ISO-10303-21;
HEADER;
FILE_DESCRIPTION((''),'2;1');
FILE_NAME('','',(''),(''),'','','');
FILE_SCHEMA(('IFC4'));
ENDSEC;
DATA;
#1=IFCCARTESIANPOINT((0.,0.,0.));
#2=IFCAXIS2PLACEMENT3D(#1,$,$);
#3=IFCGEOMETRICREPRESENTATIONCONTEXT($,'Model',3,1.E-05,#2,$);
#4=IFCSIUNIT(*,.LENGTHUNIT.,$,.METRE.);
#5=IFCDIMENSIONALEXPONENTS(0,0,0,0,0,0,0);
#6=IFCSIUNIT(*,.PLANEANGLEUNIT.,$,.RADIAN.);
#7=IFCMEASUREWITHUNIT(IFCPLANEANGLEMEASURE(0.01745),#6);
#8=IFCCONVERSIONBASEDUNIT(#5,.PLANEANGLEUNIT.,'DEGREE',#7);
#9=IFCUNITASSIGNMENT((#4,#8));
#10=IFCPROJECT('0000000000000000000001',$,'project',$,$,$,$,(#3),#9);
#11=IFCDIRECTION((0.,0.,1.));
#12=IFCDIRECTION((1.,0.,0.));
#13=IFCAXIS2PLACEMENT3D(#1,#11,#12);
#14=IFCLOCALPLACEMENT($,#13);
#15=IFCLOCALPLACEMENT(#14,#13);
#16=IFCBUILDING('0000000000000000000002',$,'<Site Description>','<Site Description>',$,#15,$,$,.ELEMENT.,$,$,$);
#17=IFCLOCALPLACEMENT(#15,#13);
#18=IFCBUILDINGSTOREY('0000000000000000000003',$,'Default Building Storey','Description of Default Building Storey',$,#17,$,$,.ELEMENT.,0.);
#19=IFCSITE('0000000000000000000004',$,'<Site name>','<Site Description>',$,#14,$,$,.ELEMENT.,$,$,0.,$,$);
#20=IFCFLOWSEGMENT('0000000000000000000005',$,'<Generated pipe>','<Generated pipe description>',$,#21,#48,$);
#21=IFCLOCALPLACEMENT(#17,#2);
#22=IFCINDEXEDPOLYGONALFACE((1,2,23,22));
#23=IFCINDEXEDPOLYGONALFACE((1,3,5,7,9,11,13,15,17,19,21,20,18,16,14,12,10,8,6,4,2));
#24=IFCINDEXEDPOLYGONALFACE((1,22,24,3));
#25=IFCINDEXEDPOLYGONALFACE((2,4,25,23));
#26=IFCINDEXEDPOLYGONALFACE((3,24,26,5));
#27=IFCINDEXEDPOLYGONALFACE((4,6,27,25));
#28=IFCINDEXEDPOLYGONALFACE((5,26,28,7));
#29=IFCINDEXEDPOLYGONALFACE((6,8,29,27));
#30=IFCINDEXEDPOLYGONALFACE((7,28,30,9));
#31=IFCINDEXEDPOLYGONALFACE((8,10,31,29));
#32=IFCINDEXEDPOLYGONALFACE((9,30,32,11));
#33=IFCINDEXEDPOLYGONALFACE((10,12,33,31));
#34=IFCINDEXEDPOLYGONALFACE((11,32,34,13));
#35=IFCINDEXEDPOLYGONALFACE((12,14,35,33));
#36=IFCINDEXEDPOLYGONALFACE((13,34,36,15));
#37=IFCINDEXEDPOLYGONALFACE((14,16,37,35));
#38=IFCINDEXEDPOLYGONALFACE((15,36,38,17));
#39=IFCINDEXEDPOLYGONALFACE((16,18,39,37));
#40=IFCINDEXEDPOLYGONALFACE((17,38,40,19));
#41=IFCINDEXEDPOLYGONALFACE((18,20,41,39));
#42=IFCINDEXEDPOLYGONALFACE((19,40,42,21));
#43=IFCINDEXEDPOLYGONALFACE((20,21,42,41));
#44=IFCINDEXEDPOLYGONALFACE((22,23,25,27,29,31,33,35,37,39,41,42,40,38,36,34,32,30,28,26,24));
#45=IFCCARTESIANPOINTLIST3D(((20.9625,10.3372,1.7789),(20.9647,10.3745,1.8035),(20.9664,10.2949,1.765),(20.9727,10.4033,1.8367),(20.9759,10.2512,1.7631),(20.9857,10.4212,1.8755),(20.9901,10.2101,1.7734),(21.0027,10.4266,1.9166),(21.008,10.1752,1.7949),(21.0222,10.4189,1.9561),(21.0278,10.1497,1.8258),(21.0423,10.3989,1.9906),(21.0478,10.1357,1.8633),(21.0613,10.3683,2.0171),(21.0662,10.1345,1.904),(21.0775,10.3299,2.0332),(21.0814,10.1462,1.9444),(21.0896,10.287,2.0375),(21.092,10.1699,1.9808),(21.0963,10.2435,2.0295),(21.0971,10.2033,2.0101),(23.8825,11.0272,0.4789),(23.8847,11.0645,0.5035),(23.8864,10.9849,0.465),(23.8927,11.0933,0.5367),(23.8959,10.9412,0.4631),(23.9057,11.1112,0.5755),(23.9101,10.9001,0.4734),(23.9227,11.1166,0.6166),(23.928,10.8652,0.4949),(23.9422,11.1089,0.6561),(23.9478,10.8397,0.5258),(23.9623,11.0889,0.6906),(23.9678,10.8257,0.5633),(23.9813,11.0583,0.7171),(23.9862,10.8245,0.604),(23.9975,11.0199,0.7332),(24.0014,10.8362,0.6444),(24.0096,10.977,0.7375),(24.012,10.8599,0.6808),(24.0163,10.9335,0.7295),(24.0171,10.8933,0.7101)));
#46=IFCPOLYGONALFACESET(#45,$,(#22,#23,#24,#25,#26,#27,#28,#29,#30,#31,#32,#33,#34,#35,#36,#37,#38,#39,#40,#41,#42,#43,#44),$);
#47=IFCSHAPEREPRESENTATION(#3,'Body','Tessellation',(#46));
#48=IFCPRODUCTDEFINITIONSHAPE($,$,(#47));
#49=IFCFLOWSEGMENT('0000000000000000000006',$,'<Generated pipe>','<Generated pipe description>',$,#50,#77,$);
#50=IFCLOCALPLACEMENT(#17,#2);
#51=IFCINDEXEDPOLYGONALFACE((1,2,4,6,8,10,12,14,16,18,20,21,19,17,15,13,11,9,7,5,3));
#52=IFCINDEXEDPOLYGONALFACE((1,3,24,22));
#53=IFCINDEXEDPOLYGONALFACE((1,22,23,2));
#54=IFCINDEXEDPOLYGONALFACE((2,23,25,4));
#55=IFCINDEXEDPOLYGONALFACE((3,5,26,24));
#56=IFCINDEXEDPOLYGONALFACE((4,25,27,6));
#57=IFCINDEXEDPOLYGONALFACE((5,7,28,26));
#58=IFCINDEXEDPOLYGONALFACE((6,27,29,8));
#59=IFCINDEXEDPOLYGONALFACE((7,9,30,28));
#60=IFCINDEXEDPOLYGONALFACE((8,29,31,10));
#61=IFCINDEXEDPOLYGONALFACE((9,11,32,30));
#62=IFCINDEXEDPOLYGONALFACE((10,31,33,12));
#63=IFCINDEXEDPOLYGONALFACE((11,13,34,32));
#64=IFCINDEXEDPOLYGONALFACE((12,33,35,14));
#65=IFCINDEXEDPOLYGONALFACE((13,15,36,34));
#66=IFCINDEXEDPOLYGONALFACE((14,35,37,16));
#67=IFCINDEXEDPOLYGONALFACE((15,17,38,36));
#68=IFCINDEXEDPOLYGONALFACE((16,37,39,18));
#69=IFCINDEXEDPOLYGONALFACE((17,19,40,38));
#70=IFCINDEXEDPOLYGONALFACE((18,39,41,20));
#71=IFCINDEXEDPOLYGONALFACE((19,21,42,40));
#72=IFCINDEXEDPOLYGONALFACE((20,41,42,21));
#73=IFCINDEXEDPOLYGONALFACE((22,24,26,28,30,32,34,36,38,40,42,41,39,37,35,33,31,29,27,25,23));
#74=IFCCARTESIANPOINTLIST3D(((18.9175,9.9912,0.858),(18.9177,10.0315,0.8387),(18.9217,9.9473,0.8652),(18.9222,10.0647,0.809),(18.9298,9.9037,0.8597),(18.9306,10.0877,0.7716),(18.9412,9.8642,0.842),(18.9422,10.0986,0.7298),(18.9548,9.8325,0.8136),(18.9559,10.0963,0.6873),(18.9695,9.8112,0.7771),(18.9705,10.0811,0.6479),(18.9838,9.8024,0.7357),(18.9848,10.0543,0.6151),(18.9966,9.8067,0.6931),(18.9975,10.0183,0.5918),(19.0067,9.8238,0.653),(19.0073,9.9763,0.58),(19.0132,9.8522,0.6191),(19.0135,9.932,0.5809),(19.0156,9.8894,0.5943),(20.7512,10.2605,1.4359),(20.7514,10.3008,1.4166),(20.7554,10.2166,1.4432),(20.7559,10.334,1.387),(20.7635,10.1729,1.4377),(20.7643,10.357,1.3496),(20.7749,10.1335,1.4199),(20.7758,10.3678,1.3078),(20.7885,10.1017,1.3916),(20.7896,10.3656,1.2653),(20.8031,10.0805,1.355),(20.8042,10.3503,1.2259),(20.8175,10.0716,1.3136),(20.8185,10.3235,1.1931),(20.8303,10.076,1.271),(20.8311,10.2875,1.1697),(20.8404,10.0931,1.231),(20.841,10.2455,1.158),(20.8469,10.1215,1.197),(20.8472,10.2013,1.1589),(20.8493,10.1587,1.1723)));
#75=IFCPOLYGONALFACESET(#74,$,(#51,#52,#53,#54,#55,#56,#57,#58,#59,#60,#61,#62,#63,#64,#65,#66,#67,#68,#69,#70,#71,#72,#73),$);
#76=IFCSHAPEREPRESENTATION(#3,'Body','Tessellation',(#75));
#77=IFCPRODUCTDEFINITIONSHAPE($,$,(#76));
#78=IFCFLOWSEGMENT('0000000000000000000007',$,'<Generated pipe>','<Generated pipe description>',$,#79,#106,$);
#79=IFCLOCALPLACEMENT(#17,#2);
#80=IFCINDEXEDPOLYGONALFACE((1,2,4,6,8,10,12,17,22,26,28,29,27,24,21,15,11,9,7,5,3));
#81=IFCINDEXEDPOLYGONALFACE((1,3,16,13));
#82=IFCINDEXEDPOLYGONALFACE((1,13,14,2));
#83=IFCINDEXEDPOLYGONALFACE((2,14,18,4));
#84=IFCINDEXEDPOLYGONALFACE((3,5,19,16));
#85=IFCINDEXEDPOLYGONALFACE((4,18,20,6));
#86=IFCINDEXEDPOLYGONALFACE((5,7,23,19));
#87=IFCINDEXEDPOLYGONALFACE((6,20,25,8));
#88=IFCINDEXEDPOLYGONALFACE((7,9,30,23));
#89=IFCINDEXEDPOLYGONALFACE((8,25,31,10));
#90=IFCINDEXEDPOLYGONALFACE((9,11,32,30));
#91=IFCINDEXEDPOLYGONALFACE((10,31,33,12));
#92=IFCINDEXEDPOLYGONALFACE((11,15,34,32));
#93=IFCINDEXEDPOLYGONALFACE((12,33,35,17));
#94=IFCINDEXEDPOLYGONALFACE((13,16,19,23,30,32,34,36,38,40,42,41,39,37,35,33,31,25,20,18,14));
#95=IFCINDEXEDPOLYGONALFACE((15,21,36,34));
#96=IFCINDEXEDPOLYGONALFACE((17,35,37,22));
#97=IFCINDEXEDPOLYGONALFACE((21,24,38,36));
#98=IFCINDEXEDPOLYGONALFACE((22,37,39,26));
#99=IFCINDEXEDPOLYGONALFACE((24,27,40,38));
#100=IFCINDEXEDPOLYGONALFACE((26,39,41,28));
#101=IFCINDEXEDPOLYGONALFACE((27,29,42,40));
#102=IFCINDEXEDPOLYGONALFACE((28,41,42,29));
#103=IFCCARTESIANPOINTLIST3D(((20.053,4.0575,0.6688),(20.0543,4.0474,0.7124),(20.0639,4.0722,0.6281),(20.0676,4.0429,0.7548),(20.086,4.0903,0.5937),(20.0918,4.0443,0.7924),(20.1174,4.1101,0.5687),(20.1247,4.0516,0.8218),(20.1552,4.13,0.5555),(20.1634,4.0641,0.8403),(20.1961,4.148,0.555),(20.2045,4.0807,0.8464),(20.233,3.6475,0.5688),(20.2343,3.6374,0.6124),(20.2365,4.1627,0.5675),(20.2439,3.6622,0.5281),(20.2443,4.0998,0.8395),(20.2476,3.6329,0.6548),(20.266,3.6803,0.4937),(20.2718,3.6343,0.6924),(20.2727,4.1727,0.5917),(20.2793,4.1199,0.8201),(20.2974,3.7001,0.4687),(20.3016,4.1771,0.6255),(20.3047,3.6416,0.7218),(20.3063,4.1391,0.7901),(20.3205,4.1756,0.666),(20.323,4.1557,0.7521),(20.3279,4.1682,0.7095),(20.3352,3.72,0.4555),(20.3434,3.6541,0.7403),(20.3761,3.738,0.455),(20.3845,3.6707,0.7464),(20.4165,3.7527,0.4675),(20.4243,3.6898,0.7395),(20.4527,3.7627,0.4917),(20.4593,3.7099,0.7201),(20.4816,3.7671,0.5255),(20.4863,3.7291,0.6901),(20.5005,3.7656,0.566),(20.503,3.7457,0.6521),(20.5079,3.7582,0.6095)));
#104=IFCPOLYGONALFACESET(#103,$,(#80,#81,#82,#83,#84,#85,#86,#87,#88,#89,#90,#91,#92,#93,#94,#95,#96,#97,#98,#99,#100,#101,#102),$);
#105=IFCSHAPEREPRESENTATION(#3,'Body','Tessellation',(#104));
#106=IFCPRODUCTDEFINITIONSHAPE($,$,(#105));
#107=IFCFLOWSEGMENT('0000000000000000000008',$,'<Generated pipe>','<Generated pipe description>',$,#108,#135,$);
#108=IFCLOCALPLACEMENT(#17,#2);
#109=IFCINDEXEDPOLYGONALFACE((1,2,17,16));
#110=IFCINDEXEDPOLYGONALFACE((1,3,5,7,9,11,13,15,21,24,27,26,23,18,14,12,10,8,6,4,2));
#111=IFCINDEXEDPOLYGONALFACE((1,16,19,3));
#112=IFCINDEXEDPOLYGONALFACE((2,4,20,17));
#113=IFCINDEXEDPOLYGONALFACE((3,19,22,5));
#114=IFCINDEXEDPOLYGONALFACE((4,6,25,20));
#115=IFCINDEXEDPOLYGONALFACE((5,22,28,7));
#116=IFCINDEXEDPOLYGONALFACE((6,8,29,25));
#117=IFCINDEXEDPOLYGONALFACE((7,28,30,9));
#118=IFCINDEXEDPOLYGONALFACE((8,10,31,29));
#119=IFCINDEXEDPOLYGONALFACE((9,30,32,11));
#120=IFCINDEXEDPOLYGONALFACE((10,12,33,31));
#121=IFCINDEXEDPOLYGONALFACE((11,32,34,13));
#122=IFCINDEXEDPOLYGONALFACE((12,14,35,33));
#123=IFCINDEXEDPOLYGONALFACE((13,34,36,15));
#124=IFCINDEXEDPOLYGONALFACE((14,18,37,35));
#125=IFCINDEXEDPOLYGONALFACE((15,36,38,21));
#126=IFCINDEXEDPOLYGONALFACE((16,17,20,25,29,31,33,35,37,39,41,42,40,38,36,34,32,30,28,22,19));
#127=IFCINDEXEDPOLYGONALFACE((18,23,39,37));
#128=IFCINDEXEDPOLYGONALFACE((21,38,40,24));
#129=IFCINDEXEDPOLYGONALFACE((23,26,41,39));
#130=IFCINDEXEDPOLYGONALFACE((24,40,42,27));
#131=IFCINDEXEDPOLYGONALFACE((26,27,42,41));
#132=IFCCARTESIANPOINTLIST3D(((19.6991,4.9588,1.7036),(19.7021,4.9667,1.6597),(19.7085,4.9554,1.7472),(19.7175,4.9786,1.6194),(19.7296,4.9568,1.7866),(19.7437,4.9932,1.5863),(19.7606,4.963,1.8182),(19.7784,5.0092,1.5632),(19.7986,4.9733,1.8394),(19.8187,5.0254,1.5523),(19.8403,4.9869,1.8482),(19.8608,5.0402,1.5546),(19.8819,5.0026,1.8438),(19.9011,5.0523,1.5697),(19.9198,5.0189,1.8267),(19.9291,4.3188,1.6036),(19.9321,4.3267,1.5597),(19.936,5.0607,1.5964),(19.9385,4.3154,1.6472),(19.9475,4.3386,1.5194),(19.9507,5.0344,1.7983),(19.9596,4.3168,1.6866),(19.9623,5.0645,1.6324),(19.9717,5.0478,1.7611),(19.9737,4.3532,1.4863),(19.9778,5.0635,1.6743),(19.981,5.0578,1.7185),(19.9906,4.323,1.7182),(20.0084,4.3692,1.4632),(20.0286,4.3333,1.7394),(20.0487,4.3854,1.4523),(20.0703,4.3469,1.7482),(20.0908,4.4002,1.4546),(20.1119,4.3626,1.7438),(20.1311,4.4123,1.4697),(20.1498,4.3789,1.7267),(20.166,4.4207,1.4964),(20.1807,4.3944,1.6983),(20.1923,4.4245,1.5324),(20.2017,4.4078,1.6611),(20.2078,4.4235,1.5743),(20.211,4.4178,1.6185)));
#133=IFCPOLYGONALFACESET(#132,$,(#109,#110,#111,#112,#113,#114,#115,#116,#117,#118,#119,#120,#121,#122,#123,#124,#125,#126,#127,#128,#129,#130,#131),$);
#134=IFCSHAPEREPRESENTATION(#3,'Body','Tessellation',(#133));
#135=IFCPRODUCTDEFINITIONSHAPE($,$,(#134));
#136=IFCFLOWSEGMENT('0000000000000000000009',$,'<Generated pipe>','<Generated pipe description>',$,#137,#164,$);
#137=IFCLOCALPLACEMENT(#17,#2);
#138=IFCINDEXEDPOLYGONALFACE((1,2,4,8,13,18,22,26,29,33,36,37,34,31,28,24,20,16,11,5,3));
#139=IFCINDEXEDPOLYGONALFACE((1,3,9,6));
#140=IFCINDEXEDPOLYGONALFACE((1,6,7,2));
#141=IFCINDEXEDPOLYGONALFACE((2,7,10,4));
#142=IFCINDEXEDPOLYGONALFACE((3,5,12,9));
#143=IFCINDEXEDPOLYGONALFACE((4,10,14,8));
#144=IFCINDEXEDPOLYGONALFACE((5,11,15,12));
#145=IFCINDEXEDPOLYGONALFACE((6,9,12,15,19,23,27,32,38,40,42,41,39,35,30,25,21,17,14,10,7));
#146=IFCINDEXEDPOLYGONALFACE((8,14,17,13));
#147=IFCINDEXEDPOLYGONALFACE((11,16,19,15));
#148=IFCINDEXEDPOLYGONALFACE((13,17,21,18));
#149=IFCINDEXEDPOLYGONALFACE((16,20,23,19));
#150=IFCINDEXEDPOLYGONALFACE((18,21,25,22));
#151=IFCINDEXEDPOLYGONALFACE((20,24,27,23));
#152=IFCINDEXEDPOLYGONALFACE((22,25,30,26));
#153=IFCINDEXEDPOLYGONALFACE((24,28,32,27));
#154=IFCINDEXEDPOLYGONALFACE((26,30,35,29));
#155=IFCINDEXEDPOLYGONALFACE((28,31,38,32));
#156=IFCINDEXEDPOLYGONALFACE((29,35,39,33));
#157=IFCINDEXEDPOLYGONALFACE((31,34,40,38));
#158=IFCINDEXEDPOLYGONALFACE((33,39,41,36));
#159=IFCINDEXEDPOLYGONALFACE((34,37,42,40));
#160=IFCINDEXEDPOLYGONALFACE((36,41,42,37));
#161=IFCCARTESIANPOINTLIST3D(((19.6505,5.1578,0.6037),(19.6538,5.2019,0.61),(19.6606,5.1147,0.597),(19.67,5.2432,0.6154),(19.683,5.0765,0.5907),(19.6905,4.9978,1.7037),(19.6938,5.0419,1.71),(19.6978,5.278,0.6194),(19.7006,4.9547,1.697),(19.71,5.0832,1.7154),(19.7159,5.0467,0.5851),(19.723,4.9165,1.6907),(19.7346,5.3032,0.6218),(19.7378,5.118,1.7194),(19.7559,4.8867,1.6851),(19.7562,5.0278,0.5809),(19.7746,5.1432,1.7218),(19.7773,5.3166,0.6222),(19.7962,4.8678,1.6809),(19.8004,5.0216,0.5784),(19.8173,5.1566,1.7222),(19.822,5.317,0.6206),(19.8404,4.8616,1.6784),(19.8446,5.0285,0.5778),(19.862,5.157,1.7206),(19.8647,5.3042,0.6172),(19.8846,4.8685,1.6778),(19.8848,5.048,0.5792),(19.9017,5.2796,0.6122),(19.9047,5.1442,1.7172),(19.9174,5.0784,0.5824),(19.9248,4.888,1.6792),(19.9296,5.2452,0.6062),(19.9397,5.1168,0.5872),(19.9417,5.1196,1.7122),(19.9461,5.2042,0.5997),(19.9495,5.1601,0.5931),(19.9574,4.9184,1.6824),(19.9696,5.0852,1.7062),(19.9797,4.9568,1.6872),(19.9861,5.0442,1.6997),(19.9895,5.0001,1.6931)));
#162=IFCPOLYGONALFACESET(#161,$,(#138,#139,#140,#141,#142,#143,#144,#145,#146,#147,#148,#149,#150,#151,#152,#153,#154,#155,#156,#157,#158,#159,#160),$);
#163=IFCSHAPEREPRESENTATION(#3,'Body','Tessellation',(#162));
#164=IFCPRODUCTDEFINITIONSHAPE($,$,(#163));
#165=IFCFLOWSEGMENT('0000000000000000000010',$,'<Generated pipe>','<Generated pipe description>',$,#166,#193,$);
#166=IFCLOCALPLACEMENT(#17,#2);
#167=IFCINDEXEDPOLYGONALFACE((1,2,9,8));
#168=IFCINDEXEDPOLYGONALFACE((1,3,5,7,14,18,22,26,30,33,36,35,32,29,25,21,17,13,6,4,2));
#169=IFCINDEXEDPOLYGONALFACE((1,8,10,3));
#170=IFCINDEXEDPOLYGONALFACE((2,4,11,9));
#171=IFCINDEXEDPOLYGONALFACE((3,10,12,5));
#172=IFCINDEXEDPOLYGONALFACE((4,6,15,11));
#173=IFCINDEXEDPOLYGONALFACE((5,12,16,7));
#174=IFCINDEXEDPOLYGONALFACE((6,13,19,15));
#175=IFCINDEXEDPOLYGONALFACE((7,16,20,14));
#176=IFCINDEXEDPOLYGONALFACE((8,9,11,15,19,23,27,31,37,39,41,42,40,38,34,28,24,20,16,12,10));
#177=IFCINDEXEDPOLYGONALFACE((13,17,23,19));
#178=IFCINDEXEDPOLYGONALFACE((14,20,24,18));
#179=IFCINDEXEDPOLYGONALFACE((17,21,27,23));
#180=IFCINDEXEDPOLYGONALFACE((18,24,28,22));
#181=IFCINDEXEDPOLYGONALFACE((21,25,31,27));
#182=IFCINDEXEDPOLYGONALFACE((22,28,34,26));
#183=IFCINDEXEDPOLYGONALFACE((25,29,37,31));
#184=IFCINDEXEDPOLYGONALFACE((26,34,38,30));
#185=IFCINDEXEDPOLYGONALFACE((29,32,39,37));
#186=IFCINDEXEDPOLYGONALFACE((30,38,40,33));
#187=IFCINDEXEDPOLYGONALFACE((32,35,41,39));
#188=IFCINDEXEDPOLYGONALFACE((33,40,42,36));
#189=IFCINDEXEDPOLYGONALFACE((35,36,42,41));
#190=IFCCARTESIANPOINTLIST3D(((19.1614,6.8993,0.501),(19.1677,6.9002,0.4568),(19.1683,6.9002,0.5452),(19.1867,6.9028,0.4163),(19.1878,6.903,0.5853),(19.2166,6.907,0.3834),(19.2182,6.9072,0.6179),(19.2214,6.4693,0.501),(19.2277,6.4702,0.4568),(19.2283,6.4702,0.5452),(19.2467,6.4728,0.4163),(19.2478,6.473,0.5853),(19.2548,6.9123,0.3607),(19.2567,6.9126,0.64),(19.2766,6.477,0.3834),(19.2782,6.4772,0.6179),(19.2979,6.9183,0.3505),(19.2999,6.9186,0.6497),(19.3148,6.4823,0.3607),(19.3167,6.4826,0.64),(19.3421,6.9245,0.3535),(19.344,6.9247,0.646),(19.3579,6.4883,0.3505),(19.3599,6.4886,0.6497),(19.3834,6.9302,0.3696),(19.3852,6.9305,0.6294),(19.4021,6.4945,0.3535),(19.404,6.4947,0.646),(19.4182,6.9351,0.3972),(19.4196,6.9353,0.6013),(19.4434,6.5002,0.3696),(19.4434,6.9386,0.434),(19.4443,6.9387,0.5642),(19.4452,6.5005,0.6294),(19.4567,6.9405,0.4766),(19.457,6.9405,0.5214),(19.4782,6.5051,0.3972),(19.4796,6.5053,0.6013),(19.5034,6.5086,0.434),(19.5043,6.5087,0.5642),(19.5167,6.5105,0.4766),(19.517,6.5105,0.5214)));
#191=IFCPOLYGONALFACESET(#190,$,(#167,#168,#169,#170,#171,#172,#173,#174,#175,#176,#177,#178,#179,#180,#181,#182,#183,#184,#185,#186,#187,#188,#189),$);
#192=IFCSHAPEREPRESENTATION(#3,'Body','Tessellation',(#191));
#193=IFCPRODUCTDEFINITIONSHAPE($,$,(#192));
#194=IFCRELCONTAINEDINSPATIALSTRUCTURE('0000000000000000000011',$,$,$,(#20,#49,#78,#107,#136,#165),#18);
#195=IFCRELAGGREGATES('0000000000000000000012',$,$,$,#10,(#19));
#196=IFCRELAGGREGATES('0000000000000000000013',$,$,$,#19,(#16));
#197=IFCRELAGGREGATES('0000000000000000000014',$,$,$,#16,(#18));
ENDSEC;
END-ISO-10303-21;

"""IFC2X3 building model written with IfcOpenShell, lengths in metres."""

from ifc_helpers import new_model, entity, si_unit, converted_unit, frame, origin, origin_with_axes, origin_2d_with_axis, place, context, project, spatial, circle, extrude, element, save


model = new_model("IFC2X3")

# Units and contexts
model_context = context("Model", 3, precision=1e-05, world=origin())
ifc_project = project(units=[si_unit("LENGTHUNIT", "METRE"), converted_unit("PLANEANGLEUNIT", "DEGREE", entity("IfcPlaneAngleMeasure", 0.01745), si_unit("PLANEANGLEUNIT", "RADIAN"), dimensions=[0, 0, 0, 0, 0, 0, 0])], contexts=[model_context])

# Site, building, storey
site_placement = place(None, origin_with_axes())
site = spatial("IfcSite", under=ifc_project, at=site_placement, Name="<Site name>", Description="<Site Description>", CompositionType="ELEMENT", RefElevation=0.0)
building_placement = place(site_placement, origin_with_axes())
building = spatial("IfcBuilding", under=site, at=building_placement, Name="<Site Description>", Description="<Site Description>", CompositionType="ELEMENT")
storey_placement = place(building_placement, origin_with_axes())
storey = spatial("IfcBuildingStorey", under=building, at=storey_placement, Name="Default Building Storey", Description="Description of Default Building Storey", CompositionType="ELEMENT", Elevation=0.0)

# Flow segments
flow_segment_1_placement = place(storey_placement, frame((23.95, 10.97, 0.6), z_axis=(-0.892983, -0.211013, 0.397561), x_axis=(0.208589, 0.588691, 0.780982)))
element("IfcFlowSegment", 1, at=flow_segment_1_placement, inside=storey, Name="<Generated pipe>", Description="<Generated pipe description>", context=model_context, shape_type="SweptSolid", body=[
    extrude(circle(Radius=0.15, at=origin_2d_with_axis()), origin_with_axes(), (0.0, 0.0, 1.0), 3.2699),
])
flow_segment_2_placement = place(storey_placement, frame((20.8, 10.22, 1.3), z_axis=(-0.94453, -0.138703, -0.297699), x_axis=(-0.294308, 0.759756, 0.579788)))
element("IfcFlowSegment", 2, at=flow_segment_2_placement, inside=storey, Name="<Generated pipe>", Description="<Generated pipe description>", context=model_context, shape_type="SweptSolid", body=[
    extrude(circle(Radius=0.15, at=origin_2d_with_axis()), origin_with_axes(), (0.0, 0.0, 1.0), 1.9414),
])
flow_segment_3_placement = place(storey_placement, frame((20.37, 3.7, 0.6), z_axis=(-0.392325, 0.89363, 0.217959), x_axis=(0.362035, -0.067813, 0.929695)))
element("IfcFlowSegment", 3, at=flow_segment_3_placement, inside=storey, Name="<Generated pipe>", Description="<Generated pipe description>", context=model_context, shape_type="SweptSolid", body=[
    extrude(circle(Radius=0.15, at=origin_2d_with_axis()), origin_with_axes(), (0.0, 0.0, 1.0), 0.4588),
])
flow_segment_4_placement = place(storey_placement, frame((20.07, 4.37, 1.6), z_axis=(-0.334601, 0.931063, 0.145479), x_axis=(0.737834, 0.162807, 0.655053)))
element("IfcFlowSegment", 4, at=flow_segment_4_placement, inside=storey, Name="<Generated pipe>", Description="<Generated pipe description>", context=model_context, shape_type="SweptSolid", body=[
    extrude(circle(Radius=0.15, at=origin_2d_with_axis()), origin_with_axes(), (0.0, 0.0, 1.0), 0.6874),
])
flow_segment_5_placement = place(storey_placement, frame((19.84, 5.01, 1.7), z_axis=(-0.035962, 0.143847, -0.988946), x_axis=(0.864174, 0.501478, 0.041518)))
element("IfcFlowSegment", 5, at=flow_segment_5_placement, inside=storey, Name="<Generated pipe>", Description="<Generated pipe description>", context=model_context, shape_type="SweptSolid", body=[
    extrude(circle(Radius=0.15, at=origin_2d_with_axis()), origin_with_axes(), (0.0, 0.0, 1.0), 1.1123),
])
flow_segment_6_placement = place(storey_placement, frame((19.37, 6.49, 0.5), z_axis=(-0.138196, 0.990405, 0.0), x_axis=(0.730564, 0.101939, 0.675192)))
element("IfcFlowSegment", 6, at=flow_segment_6_placement, inside=storey, Name="<Generated pipe>", Description="<Generated pipe description>", context=model_context, shape_type="SweptSolid", body=[
    extrude(circle(Radius=0.15, at=origin_2d_with_axis()), origin_with_axes(), (0.0, 0.0, 1.0), 0.4342),
])

save(model, "model.ifc")
